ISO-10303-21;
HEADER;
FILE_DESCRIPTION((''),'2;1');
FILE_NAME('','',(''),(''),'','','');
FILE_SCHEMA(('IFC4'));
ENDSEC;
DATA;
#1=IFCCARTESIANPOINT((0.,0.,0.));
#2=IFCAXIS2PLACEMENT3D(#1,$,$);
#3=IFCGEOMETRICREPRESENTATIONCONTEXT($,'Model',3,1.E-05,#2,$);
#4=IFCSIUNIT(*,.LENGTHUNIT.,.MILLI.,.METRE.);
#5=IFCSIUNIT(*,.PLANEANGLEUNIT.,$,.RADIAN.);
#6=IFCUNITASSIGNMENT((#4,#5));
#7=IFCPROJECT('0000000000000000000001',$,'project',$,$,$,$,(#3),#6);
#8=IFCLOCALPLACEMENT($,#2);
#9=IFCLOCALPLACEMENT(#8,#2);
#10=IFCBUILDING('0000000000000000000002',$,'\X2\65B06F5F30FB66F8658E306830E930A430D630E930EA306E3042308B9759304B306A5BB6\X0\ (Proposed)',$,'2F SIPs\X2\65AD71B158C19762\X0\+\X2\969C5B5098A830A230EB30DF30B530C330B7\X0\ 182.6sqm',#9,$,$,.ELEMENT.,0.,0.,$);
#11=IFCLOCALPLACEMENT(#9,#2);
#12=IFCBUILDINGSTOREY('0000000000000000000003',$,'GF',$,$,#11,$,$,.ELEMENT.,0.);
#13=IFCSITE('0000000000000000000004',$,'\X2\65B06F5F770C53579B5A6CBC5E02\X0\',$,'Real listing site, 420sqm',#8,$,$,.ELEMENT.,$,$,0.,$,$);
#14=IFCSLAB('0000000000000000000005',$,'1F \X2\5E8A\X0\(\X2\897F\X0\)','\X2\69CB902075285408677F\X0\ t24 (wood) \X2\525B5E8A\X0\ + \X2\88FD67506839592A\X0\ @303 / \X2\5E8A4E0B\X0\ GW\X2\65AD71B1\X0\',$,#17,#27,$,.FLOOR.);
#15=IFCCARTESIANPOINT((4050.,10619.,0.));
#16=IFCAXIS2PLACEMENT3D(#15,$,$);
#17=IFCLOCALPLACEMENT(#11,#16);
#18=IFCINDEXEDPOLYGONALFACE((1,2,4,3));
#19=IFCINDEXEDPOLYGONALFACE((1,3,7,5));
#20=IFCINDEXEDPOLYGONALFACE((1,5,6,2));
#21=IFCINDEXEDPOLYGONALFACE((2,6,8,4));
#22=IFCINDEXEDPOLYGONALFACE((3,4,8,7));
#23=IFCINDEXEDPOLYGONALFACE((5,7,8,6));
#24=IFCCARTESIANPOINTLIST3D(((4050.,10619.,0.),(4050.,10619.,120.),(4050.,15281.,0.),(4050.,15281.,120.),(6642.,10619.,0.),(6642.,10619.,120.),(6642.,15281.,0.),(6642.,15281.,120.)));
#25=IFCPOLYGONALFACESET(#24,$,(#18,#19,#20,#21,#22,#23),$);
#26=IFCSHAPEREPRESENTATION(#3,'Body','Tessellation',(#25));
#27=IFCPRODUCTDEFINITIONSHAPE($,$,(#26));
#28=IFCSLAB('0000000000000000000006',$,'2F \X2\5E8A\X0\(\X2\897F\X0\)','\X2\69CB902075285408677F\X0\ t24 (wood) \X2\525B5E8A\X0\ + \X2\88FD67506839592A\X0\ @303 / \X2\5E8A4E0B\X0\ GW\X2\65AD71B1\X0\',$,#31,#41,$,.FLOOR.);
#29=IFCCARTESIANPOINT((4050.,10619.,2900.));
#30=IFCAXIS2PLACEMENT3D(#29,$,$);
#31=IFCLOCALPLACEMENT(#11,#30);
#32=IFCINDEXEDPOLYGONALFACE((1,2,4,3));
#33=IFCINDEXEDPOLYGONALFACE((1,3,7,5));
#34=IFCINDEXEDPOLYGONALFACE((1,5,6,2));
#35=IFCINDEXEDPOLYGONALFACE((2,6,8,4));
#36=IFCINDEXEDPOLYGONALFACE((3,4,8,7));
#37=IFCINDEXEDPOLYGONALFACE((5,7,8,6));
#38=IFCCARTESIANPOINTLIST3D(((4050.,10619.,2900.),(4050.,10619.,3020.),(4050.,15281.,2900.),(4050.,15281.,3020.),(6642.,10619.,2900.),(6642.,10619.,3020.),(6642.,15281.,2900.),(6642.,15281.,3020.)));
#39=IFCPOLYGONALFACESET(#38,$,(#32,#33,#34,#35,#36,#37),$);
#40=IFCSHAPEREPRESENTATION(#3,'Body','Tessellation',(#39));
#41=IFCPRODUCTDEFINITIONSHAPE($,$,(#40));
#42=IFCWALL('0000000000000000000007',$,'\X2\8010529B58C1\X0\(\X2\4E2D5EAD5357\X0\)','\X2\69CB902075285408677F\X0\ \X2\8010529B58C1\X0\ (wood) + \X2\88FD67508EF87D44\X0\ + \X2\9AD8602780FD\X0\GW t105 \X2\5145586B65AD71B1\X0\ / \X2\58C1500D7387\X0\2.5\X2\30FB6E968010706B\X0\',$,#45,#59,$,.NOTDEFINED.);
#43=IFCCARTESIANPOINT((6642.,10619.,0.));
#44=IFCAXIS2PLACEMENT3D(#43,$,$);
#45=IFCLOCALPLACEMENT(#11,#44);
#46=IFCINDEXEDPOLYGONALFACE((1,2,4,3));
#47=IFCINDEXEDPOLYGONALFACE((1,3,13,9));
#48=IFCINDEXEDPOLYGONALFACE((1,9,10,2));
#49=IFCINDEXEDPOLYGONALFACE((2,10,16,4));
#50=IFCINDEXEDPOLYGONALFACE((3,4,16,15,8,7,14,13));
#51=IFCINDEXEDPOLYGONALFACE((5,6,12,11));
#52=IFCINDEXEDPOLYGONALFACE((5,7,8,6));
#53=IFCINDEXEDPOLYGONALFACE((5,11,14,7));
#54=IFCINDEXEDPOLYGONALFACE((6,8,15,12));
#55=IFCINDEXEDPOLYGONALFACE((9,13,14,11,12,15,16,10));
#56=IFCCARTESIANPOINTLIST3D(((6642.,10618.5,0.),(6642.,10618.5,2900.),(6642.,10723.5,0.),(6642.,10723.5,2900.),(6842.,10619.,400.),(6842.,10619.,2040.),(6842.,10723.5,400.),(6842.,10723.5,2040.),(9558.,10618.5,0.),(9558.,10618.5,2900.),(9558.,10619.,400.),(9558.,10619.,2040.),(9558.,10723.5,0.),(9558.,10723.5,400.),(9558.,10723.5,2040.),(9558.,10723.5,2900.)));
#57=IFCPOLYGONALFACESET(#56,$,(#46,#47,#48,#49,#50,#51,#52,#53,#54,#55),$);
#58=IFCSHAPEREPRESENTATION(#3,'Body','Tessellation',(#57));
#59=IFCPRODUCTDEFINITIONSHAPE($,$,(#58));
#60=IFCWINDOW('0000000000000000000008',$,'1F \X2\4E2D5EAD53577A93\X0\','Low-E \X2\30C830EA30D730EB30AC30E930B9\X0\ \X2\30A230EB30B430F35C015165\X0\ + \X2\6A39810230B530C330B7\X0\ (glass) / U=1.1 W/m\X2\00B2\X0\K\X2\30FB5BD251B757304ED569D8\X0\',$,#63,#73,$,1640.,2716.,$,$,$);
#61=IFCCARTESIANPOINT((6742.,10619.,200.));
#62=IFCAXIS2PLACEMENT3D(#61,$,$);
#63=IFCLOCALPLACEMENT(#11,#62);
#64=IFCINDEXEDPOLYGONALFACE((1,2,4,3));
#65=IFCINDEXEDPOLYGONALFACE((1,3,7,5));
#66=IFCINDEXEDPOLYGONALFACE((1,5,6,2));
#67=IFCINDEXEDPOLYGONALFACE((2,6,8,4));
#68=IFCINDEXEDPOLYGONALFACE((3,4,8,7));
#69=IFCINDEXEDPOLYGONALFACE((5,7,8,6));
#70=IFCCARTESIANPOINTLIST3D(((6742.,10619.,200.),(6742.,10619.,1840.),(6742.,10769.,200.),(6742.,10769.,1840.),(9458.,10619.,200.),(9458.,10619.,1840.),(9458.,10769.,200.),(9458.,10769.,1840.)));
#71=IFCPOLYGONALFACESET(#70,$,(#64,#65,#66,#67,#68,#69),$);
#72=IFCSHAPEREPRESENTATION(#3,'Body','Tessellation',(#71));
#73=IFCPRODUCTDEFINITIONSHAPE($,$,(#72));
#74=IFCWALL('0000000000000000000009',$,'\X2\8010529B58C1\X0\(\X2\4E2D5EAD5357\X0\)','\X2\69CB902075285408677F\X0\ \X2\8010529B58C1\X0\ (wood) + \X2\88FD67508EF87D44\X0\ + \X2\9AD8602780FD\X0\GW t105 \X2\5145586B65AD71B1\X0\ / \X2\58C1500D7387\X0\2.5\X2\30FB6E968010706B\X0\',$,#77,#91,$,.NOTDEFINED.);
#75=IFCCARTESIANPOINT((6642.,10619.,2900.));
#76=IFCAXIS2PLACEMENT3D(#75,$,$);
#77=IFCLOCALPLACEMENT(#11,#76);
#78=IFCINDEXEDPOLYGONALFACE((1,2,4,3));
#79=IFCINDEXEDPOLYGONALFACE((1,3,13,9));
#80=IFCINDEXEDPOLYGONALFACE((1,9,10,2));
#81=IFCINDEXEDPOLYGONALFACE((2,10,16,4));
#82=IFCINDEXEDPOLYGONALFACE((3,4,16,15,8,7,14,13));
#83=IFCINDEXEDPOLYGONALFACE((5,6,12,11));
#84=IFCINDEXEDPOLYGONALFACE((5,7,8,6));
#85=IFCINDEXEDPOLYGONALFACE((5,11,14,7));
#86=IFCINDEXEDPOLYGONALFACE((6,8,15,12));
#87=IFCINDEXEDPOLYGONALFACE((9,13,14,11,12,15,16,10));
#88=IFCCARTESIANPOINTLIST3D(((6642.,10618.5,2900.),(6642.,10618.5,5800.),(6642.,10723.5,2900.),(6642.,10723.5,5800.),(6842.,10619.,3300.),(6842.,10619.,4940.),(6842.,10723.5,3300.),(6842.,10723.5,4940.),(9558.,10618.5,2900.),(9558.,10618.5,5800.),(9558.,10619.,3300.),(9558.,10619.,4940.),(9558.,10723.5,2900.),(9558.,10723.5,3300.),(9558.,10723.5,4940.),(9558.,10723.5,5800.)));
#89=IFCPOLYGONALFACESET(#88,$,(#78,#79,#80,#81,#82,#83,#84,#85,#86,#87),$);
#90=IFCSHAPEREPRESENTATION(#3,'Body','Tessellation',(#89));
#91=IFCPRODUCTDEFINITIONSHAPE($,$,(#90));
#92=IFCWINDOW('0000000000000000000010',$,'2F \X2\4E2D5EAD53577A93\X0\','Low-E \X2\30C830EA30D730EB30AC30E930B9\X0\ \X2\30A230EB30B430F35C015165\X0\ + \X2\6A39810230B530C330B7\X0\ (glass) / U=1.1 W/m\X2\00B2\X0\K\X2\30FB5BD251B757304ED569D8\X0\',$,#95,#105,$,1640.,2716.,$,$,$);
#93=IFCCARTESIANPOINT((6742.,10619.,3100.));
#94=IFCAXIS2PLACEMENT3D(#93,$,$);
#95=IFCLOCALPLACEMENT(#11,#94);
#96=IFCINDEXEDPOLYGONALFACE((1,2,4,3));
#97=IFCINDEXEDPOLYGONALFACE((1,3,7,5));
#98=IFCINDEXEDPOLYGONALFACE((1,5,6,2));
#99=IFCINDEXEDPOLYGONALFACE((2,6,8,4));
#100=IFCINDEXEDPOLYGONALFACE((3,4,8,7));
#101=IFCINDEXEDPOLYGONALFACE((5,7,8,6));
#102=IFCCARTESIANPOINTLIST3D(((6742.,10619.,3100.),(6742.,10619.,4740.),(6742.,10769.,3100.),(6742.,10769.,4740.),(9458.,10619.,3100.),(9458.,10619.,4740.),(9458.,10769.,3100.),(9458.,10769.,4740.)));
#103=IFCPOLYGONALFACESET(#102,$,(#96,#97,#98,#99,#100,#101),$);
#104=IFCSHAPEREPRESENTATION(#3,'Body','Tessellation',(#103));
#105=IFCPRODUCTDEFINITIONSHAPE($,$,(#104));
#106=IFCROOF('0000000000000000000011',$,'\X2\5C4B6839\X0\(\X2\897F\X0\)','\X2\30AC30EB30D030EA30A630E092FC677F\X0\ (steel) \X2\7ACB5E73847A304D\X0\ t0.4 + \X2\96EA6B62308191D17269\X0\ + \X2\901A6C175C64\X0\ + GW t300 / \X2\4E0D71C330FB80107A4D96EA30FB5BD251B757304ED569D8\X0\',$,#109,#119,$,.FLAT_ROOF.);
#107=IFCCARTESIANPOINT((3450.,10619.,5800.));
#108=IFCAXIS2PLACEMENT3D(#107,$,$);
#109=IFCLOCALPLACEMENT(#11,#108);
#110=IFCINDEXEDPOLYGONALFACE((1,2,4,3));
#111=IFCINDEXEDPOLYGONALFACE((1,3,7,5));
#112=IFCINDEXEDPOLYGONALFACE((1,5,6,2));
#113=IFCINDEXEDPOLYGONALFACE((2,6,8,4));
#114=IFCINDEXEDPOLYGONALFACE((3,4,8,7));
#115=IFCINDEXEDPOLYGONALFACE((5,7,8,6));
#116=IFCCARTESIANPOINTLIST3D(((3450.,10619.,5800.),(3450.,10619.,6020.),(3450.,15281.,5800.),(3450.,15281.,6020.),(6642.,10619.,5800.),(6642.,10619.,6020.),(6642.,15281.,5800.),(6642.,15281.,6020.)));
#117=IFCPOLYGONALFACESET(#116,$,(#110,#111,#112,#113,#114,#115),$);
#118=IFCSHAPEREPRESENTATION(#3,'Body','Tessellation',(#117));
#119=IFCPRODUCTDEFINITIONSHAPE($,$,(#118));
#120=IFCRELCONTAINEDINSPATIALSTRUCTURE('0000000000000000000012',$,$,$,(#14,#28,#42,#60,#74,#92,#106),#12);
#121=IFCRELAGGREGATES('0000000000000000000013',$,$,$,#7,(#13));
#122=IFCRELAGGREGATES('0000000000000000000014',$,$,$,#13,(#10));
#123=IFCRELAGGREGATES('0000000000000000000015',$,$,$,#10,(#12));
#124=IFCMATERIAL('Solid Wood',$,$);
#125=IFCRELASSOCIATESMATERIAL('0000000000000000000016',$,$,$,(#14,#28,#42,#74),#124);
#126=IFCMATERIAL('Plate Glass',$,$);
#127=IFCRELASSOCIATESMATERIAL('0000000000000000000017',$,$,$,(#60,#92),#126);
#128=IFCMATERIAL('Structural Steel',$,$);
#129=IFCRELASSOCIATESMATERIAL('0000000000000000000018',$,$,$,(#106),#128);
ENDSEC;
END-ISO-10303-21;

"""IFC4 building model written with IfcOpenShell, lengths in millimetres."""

from ifc_helpers import new_model, si_unit, frame, frame_2d, origin, place, context, project, spatial, rectangle, extrude, material, element, fill, save


model = new_model("IFC4")

# Units and contexts
model_context = context("Model", 3, precision=1e-05, world=origin())
ifc_project = project(units=[si_unit("LENGTHUNIT", "METRE", prefix="MILLI"), si_unit("PLANEANGLEUNIT", "RADIAN")], contexts=[model_context])

# Site, building, storey
site_placement = place(None, origin())
site = spatial("IfcSite", under=ifc_project, at=site_placement, Name="新潟県南魚沼市", ObjectType="Real listing site, 420sqm", CompositionType="ELEMENT", RefElevation=0.0)
building_placement = place(site_placement, origin())
building = spatial("IfcBuilding", under=site, at=building_placement, Name="新潟・書斎とライブラリのある静かな家 (Proposed)", ObjectType="2F SIPs断熱壁面+障子風アルミサッシ 182.6sqm", CompositionType="ELEMENT", ElevationOfRefHeight=0.0, ElevationOfTerrain=0.0)
storey_placement = place(building_placement, origin())
storey = spatial("IfcBuildingStorey", under=building, at=storey_placement, Name="GF", CompositionType="ELEMENT", Elevation=0.0)

# Shared definitions
ifc_material_1 = material(Name="Solid Wood")

# Slabs
slab_1_placement = place(storey_placement, frame((4050.0, 10619.0, 0.0)))
element("IfcSlab", 1, at=slab_1_placement, inside=storey, material=ifc_material_1, Name="1F 床(西)", Description="構造用合板 t24 (wood) 剛床 + 製材根太 @303 / 床下 GW断熱", PredefinedType="FLOOR", context=model_context, shape_type="SweptSolid", body=[
    extrude(rectangle(XDim=2592.0, YDim=4662.0, at=frame_2d((1296.0, 2331.0))), frame((4050.0, 10619.0, 0.0)), (0.0, 0.0, 1.0), 120.0),
])
slab_2_placement = place(storey_placement, frame((4050.0, 10619.0, 2900.0)))
element("IfcSlab", 2, at=slab_2_placement, inside=storey, material=ifc_material_1, Name="2F 床(西)", Description="構造用合板 t24 (wood) 剛床 + 製材根太 @303 / 床下 GW断熱", PredefinedType="FLOOR", context=model_context, shape_type="SweptSolid", body=[
    extrude(rectangle(XDim=2592.0, YDim=4662.0, at=frame_2d((1296.0, 2331.0))), frame((4050.0, 10619.0, 2900.0)), (0.0, 0.0, 1.0), 120.0),
])

# Wall, opening, window
wall_1_placement = place(storey_placement, frame((6642.0, 10619.0, 0.0)))
wall_1 = element("IfcWall", 3, at=wall_1_placement, inside=storey, material=ifc_material_1, Name="耐力壁(中庭南)", Description="構造用合板 耐力壁 (wood) + 製材軸組 + 高性能GW t105 充填断熱 / 壁倍率2.5・準耐火", PredefinedType="NOTDEFINED", context=model_context, shape_type="SweptSolid", body=[
    extrude(rectangle(XDim=2916.0, YDim=105.0, at=frame_2d((1458.0, 52.0))), frame((6642.0, 10619.0, 0.0)), (0.0, 0.0, 1.0), 2900.0),
])
opening_1_placement = place(storey_placement, frame((6742.0, 10619.0, 200.0)))
opening_1 = element("IfcOpeningElement", 4, at=opening_1_placement, cuts=wall_1, PredefinedType="NOTDEFINED", context=model_context, shape_type="SweptSolid", body=[
    extrude(rectangle(XDim=2716.0, YDim=150.0, at=frame_2d((1358.0, 75.0))), frame((6742.0, 10619.0, 200.0)), (0.0, 0.0, 1.0), 1640.0),
])
ifc_material_2 = material(Name="Plate Glass")
window_1_placement = place(storey_placement, frame((6742.0, 10619.0, 200.0)))
window_1 = element("IfcWindow", 5, at=window_1_placement, inside=storey, material=ifc_material_2, Name="1F 中庭南窓", Description="Low-E トリプルガラス アルゴン封入 + 樹脂サッシ (glass) / U=1.1 W/m²K・寒冷地仕様", OverallHeight=1640.0, OverallWidth=2716.0, context=model_context, shape_type="SweptSolid", body=[
    extrude(rectangle(XDim=2716.0, YDim=150.0, at=frame_2d((1358.0, 75.0))), frame((6742.0, 10619.0, 200.0)), (0.0, 0.0, 1.0), 1640.0),
])
fill(opening_1, window_1)

# Wall, opening, window
wall_2_placement = place(storey_placement, frame((6642.0, 10619.0, 2900.0)))
wall_2 = element("IfcWall", 6, at=wall_2_placement, inside=storey, material=ifc_material_1, Name="耐力壁(中庭南)", Description="構造用合板 耐力壁 (wood) + 製材軸組 + 高性能GW t105 充填断熱 / 壁倍率2.5・準耐火", PredefinedType="NOTDEFINED", context=model_context, shape_type="SweptSolid", body=[
    extrude(rectangle(XDim=2916.0, YDim=105.0, at=frame_2d((1458.0, 52.0))), frame((6642.0, 10619.0, 2900.0)), (0.0, 0.0, 1.0), 2900.0),
])
opening_2_placement = place(storey_placement, frame((6742.0, 10619.0, 3100.0)))
opening_2 = element("IfcOpeningElement", 7, at=opening_2_placement, cuts=wall_2, PredefinedType="NOTDEFINED", context=model_context, shape_type="SweptSolid", body=[
    extrude(rectangle(XDim=2716.0, YDim=150.0, at=frame_2d((1358.0, 75.0))), frame((6742.0, 10619.0, 3100.0)), (0.0, 0.0, 1.0), 1640.0),
])
window_2_placement = place(storey_placement, frame((6742.0, 10619.0, 3100.0)))
window_2 = element("IfcWindow", 8, at=window_2_placement, inside=storey, material=ifc_material_2, Name="2F 中庭南窓", Description="Low-E トリプルガラス アルゴン封入 + 樹脂サッシ (glass) / U=1.1 W/m²K・寒冷地仕様", OverallHeight=1640.0, OverallWidth=2716.0, context=model_context, shape_type="SweptSolid", body=[
    extrude(rectangle(XDim=2716.0, YDim=150.0, at=frame_2d((1358.0, 75.0))), frame((6742.0, 10619.0, 3100.0)), (0.0, 0.0, 1.0), 1640.0),
])
fill(opening_2, window_2)

# Roof
ifc_material_3 = material(Name="Structural Steel")
for number, where, name in (
    (9, (3450.0, 10619.0, 5800.0), "屋根(西)"),
):
    element("IfcRoof", number, at=place(storey_placement, frame(where)), inside=storey, material=ifc_material_3, Name=name, Description="ガルバリウム鋼板 (steel) 立平葺き t0.4 + 雪止め金物 + 通気層 + GW t300 / 不燃・耐積雪・寒冷地仕様", PredefinedType="FLAT_ROOF", context=model_context, shape_type="SweptSolid", body=[
        extrude(rectangle(XDim=3192.0, YDim=4662.0, at=frame_2d((1596.0, 2331.0))), frame((3450.0, 10619.0, 5800.0)), (0.0, 0.0, 1.0), 220.0),
    ])

save(model, "model.ifc")
